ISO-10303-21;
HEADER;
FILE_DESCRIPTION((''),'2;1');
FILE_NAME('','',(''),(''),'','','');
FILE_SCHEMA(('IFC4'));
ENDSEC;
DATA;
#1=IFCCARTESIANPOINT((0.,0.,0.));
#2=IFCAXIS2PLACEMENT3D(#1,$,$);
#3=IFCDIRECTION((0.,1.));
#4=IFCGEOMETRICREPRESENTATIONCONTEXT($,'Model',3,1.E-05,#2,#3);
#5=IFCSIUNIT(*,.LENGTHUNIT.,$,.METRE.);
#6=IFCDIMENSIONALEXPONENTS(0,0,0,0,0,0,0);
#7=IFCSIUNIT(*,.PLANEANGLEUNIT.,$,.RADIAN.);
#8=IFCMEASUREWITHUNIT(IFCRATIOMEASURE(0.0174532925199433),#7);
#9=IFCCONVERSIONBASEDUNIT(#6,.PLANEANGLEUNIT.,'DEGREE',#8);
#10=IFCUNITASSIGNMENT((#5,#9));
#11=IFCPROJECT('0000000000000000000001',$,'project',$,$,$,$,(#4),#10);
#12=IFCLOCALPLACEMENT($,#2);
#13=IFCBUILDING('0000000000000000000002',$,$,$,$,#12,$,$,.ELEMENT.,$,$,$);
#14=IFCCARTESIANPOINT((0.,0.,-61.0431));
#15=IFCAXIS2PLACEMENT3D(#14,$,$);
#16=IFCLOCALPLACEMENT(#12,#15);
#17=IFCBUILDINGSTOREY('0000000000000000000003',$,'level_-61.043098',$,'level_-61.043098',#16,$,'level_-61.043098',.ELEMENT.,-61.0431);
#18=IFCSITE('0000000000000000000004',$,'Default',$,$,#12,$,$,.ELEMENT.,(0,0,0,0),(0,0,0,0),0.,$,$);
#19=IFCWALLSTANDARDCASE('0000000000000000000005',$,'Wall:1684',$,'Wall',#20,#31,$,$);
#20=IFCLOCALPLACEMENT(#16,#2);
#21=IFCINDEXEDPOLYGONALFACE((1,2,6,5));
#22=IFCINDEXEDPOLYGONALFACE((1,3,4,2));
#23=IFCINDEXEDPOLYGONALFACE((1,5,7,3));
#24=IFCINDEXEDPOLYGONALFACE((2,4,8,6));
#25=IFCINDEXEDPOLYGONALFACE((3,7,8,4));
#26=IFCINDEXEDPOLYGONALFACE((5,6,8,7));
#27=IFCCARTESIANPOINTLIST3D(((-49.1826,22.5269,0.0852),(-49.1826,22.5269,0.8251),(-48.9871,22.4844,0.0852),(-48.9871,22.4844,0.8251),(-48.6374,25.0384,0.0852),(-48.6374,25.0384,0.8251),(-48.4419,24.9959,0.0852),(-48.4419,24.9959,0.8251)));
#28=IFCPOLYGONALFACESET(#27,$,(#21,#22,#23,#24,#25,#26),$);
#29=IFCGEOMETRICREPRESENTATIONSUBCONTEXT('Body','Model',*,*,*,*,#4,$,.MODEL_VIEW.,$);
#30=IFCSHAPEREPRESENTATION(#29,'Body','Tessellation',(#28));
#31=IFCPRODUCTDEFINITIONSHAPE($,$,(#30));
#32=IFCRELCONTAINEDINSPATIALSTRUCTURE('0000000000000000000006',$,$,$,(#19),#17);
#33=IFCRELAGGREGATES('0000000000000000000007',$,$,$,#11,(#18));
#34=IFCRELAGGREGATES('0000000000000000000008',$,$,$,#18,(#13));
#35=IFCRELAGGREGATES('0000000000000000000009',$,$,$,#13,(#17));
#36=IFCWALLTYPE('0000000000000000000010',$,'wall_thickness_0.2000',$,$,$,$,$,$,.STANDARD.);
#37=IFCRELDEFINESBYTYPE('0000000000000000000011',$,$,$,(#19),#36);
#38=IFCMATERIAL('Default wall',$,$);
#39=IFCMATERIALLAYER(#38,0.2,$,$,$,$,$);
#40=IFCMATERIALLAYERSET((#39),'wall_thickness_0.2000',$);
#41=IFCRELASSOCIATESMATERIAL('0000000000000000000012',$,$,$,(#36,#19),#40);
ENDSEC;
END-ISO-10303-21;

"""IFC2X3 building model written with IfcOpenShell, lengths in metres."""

from ifc_helpers import new_model, entity, si_unit, converted_unit, direction, frame, origin, place, context, subcontext, project, spatial, polyline, outline, extrude, material, layer, layer_set, layer_usage, type_object, element, save


model = new_model("IFC2X3")

# Units and contexts
model_context = context("Model", 3, precision=1e-05, world=origin(), true_north=direction((0.0, 1.0)))
body_context = subcontext(model_context, "Body", "Model", "MODEL_VIEW")
ifc_project = project(units=[si_unit("LENGTHUNIT", "METRE"), converted_unit("PLANEANGLEUNIT", "DEGREE", entity("IfcRatioMeasure", 0.0174532925199433), si_unit("PLANEANGLEUNIT", "RADIAN"), dimensions=[0, 0, 0, 0, 0, 0, 0])], contexts=[model_context])

# Site, building, storey
placement_1 = place(None, origin())
site = spatial("IfcSite", under=ifc_project, at=placement_1, Name="Default", CompositionType="ELEMENT", RefLatitude=(0, 0, 0, 0), RefLongitude=(0, 0, 0, 0), RefElevation=0.0)
building = spatial("IfcBuilding", under=site, at=placement_1, CompositionType="ELEMENT")
storey_placement = place(placement_1, frame((0.0, 0.0, -61.0431)))
storey = spatial("IfcBuildingStorey", under=building, at=storey_placement, Name="level_-61.043098", ObjectType="level_-61.043098", LongName="level_-61.043098", CompositionType="ELEMENT", Elevation=-61.0431)

# Shared definitions
ifc_material_1 = material(Name="Default wall")
ifc_layer = layer(ifc_material_1, 0.2)
ifc_layer_set = layer_set([ifc_layer], Name="wall_thickness_0.2000")
ifc_layer_usage = layer_usage(ifc_layer_set, "AXIS2", "POSITIVE", -0.1)
wall_type = type_object("IfcWallType", Name="wall_thickness_0.2000", PredefinedType="STANDARD", material=ifc_layer_set)

# Wall
placement_2 = place(placement_1, frame((0.0, 0.0, -60.9579)))
wall_1_placement = place(placement_2, frame((-49.0848, 22.5056, 0.0), z_axis=(0.0, 0.0, 1.0), x_axis=(0.21213, 0.977241, 0.0)))
element("IfcWallStandardCase", 1, at=wall_1_placement, inside=storey, type_object=wall_type, material=ifc_layer_usage, Name="Wall:1684", ObjectType="Wall", context=body_context, shape_type="SweptSolid", body=[
    extrude(outline(polyline([(2.57, -0.1), (2.57, 0.1), (0.0, 0.1), (0.0, -0.1), (2.57, -0.1)])), origin(), (0.0, 0.0, 1.0), 0.7399),
])

save(model, "model.ifc")
